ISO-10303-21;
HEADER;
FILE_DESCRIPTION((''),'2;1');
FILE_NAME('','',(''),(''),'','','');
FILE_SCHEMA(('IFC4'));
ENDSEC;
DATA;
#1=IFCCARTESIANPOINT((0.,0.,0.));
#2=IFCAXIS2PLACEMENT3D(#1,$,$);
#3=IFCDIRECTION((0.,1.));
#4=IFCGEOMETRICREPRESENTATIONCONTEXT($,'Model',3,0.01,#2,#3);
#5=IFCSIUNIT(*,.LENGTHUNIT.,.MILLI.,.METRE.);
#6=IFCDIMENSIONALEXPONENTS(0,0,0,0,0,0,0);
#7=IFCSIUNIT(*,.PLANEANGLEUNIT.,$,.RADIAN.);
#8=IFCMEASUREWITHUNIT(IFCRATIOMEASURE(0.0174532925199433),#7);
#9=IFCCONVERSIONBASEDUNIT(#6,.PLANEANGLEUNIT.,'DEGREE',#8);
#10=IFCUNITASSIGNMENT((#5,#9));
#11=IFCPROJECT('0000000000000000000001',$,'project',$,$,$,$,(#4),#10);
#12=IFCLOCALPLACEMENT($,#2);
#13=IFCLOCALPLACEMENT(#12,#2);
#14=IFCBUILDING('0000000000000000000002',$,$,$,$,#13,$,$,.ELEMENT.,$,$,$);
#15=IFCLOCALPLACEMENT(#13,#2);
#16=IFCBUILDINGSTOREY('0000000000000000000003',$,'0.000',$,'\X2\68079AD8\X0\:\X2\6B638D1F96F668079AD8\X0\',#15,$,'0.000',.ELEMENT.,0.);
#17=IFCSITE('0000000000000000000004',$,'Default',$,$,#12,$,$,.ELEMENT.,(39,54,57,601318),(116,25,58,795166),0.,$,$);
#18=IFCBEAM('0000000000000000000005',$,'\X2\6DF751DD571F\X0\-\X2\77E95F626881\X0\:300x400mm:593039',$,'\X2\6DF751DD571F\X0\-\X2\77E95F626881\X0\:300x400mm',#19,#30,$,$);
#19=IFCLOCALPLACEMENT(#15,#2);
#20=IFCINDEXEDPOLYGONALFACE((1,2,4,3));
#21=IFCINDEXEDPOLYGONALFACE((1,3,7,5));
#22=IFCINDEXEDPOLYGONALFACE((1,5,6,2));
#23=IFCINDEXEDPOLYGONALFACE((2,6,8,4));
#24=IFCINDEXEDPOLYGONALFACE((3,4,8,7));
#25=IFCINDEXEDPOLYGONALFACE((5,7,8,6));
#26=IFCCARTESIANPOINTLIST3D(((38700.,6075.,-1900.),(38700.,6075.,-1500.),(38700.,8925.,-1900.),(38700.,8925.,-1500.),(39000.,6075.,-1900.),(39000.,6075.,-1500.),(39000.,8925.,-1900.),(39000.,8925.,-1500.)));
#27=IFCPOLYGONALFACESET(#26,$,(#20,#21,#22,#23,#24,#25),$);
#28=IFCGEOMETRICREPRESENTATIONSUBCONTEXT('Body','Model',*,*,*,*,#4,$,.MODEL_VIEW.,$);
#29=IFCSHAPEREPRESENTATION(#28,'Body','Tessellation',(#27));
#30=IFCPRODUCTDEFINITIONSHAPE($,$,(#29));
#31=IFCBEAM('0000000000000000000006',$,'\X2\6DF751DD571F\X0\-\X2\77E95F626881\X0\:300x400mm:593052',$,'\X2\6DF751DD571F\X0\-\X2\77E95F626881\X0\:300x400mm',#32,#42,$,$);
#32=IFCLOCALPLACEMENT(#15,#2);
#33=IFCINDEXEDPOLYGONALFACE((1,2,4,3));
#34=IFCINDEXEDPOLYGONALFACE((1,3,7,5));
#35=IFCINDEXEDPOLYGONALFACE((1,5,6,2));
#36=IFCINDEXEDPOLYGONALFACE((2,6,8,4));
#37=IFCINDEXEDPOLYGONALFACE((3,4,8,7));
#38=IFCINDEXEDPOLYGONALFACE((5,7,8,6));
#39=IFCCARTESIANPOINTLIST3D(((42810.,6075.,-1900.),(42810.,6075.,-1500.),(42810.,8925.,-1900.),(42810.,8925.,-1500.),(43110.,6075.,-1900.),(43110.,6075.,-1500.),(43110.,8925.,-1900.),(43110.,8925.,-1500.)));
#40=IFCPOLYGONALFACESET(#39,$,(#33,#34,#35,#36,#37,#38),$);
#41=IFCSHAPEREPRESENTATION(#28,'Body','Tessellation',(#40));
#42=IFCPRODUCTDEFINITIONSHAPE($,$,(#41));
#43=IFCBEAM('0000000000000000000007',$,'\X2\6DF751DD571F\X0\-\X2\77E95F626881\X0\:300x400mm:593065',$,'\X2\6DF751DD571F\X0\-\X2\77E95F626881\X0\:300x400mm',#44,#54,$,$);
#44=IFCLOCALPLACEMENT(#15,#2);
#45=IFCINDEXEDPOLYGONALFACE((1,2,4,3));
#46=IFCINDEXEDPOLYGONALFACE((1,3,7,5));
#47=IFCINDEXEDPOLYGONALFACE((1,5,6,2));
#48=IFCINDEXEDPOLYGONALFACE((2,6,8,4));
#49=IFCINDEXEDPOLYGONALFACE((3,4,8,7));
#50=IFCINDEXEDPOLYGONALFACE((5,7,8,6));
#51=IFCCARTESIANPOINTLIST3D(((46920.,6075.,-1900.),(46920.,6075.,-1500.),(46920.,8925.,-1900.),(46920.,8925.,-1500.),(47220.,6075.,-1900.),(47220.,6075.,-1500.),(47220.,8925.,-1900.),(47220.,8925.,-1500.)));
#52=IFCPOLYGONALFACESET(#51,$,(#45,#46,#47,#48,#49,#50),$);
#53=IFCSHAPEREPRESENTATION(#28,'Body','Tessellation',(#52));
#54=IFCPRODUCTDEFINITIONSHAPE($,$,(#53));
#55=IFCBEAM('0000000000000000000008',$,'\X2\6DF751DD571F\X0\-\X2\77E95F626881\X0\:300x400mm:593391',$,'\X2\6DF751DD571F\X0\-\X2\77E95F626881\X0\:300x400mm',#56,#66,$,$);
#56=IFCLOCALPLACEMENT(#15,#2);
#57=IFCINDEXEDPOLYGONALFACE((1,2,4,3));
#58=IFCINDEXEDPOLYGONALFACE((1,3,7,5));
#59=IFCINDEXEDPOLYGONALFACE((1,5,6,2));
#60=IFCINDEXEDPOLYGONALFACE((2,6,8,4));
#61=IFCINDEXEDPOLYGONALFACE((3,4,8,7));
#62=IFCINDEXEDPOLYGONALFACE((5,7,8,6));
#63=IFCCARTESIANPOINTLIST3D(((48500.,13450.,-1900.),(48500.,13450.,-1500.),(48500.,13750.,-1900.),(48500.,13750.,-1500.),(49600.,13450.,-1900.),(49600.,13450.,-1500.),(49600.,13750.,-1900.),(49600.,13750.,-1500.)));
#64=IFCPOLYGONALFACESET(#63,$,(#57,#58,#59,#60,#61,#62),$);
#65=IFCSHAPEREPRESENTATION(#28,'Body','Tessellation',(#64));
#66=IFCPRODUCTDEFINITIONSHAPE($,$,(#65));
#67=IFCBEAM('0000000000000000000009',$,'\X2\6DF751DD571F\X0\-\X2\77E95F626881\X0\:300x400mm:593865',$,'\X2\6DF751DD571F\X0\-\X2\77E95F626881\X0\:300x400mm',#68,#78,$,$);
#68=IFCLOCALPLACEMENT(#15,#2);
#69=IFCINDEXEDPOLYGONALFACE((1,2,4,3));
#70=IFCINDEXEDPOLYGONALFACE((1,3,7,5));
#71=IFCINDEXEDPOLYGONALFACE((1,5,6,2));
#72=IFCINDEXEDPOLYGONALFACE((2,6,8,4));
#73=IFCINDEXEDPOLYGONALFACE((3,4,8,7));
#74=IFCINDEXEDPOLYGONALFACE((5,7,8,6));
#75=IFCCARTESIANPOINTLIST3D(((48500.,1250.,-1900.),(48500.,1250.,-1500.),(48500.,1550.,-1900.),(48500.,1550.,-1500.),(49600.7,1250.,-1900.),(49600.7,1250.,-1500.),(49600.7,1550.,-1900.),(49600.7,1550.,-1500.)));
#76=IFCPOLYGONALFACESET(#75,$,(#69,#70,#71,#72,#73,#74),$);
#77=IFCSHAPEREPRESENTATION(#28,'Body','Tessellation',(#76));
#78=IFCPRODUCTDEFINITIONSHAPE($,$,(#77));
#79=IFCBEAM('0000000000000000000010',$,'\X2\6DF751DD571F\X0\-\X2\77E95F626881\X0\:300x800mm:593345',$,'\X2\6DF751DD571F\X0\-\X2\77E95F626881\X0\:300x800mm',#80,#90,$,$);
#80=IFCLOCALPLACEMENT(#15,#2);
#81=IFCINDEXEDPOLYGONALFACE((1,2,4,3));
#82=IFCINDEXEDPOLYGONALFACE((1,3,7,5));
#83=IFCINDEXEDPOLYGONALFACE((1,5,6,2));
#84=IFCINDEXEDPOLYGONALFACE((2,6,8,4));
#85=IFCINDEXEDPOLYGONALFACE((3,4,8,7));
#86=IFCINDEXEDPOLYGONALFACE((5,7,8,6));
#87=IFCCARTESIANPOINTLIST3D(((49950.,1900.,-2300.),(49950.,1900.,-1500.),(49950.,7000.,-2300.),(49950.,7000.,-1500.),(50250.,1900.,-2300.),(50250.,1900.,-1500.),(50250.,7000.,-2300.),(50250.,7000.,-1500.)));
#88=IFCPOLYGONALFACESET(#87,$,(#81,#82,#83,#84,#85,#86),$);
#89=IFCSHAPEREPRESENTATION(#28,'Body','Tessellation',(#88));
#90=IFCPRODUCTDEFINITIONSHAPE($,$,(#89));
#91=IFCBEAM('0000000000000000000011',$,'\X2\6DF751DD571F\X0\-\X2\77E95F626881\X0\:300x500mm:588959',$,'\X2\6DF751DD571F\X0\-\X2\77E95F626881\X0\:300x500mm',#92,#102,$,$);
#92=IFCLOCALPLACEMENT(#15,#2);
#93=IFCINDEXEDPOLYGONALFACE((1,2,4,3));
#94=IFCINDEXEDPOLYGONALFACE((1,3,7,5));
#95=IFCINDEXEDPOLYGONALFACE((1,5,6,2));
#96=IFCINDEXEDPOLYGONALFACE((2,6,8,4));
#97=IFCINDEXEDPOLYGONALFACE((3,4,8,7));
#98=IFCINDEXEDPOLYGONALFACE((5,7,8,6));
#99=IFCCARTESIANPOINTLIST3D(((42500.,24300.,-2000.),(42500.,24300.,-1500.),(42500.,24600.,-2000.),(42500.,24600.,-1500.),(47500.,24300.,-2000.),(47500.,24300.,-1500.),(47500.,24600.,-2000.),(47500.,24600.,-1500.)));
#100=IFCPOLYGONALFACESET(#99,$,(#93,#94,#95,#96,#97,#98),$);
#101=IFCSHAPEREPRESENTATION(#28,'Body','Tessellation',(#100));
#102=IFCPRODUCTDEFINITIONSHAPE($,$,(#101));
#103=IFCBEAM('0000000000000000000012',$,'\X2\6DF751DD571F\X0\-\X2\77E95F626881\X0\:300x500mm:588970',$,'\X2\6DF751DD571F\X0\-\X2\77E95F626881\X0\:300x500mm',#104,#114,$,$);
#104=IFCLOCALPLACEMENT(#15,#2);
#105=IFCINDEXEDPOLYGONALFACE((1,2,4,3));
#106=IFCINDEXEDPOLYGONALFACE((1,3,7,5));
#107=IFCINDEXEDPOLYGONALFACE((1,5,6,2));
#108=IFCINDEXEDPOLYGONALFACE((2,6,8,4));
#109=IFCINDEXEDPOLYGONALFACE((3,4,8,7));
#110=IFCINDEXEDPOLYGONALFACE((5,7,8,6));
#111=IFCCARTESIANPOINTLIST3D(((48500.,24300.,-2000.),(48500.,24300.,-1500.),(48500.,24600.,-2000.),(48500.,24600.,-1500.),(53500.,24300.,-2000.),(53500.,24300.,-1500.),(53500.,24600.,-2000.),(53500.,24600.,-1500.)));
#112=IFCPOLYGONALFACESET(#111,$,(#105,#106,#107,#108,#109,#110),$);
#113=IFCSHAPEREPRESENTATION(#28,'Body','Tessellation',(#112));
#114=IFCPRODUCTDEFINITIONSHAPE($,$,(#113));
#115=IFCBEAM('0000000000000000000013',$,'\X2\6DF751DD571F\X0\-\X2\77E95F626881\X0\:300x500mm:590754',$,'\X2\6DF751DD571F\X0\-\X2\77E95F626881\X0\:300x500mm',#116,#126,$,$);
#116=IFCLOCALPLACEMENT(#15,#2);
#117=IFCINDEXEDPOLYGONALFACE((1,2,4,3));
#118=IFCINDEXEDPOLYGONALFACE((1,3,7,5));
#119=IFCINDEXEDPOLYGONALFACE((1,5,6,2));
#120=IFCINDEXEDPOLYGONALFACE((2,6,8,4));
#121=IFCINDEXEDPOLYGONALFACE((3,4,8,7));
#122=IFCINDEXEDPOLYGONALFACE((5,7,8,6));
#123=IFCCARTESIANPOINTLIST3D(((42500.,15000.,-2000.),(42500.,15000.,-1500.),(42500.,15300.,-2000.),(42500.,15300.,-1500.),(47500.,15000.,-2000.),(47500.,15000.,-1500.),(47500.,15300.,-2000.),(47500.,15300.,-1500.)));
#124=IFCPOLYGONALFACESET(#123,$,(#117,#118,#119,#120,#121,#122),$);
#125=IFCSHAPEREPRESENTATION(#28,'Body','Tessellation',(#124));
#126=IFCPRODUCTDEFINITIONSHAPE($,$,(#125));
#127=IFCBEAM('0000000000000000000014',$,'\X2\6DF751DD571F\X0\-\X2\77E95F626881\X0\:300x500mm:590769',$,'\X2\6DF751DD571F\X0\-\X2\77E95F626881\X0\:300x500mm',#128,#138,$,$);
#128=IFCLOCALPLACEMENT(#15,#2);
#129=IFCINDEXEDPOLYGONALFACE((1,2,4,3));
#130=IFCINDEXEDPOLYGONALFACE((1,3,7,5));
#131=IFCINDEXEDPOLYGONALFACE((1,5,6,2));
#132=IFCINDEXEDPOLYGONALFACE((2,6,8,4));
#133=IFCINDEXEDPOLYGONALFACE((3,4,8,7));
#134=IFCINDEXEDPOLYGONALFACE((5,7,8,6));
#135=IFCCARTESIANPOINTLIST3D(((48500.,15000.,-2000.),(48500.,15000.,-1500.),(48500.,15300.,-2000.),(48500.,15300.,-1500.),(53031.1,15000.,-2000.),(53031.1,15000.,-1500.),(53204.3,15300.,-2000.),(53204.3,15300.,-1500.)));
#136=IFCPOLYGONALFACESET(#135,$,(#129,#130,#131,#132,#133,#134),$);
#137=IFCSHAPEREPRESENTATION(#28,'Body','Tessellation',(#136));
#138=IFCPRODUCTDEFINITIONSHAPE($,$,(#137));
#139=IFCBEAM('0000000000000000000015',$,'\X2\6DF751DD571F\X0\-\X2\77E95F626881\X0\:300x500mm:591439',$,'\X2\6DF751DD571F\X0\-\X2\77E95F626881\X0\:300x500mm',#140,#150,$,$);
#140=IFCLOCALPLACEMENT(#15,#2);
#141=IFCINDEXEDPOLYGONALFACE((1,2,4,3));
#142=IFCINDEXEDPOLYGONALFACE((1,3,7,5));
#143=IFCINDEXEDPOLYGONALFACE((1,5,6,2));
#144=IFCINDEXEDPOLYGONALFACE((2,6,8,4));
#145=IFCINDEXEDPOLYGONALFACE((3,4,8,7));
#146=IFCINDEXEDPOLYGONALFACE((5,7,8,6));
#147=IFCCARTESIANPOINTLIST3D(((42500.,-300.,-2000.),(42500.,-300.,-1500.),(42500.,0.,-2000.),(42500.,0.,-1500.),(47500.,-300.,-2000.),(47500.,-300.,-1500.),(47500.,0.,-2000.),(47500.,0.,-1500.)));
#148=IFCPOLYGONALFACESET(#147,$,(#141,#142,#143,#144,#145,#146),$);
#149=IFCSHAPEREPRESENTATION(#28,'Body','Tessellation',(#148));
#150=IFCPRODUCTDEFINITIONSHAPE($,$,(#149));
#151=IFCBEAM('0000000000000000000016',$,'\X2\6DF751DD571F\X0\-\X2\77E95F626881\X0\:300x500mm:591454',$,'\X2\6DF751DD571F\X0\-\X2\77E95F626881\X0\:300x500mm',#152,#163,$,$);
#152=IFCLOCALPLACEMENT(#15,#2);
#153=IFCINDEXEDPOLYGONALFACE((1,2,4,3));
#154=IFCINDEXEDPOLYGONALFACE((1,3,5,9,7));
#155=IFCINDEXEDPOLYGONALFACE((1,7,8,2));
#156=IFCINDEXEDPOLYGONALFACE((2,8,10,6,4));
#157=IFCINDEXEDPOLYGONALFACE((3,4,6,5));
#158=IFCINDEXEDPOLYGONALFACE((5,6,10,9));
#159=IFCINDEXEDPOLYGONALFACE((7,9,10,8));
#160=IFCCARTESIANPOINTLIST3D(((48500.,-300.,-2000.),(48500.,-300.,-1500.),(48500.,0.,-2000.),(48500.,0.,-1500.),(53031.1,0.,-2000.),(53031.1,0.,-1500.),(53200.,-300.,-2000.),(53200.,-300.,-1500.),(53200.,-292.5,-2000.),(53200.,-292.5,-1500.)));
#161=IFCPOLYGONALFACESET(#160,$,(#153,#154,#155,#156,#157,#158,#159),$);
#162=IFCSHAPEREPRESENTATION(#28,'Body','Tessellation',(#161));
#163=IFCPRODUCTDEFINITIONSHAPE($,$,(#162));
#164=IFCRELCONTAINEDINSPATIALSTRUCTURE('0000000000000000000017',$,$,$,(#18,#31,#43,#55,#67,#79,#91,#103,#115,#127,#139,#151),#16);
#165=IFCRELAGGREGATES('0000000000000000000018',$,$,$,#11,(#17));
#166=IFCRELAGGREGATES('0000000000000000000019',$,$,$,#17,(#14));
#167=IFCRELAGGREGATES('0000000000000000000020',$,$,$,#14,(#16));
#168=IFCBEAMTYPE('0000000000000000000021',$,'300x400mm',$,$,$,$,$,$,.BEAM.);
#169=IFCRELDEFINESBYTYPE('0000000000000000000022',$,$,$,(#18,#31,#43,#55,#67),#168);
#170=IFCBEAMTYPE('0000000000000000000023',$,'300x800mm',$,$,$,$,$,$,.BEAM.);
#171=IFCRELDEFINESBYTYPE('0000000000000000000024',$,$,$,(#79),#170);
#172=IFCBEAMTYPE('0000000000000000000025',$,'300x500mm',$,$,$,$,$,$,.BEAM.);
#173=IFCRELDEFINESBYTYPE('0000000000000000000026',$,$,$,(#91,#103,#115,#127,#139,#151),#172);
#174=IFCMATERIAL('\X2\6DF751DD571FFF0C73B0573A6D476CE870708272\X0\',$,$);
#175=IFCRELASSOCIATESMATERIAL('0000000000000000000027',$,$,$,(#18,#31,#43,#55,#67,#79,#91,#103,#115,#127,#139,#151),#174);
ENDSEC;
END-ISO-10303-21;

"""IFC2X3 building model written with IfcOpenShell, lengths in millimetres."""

from ifc_helpers import new_model, entity, si_unit, converted_unit, direction, frame, frame_2d, origin, place, context, subcontext, project, spatial, rectangle, extrude, clip, halfspace, material, type_object, element, save


model = new_model("IFC2X3")

# Units and contexts
model_context = context("Model", 3, precision=0.01, world=origin(), true_north=direction((0.0, 1.0)))
body_context = subcontext(model_context, "Body", "Model", "MODEL_VIEW")
ifc_project = project(units=[si_unit("LENGTHUNIT", "METRE", prefix="MILLI"), converted_unit("PLANEANGLEUNIT", "DEGREE", entity("IfcRatioMeasure", 0.0174532925199433), si_unit("PLANEANGLEUNIT", "RADIAN"), dimensions=[0, 0, 0, 0, 0, 0, 0])], contexts=[model_context])

# Site, building, storey
site_placement = place(None, origin())
site = spatial("IfcSite", under=ifc_project, at=site_placement, Name="Default", CompositionType="ELEMENT", RefLatitude=(39, 54, 57, 601318), RefLongitude=(116, 25, 58, 795166), RefElevation=0.0)
building_placement = place(site_placement, origin())
building = spatial("IfcBuilding", under=site, at=building_placement, CompositionType="ELEMENT")
storey_placement = place(building_placement, origin())
storey = spatial("IfcBuildingStorey", under=building, at=storey_placement, Name="0.000", ObjectType="标高:正负零标高", LongName="0.000", CompositionType="ELEMENT", Elevation=0.0)

# Shared definitions
ifc_material = material(Name="混凝土，现场浇注灰色")

# Beams
beam_type_1 = type_object("IfcBeamType", Name="300x400mm", PredefinedType="BEAM")
beam_1_placement = place(storey_placement, frame((38850.0, 8925.0, -1500.0), z_axis=(0.0, 0.0, 1.0), x_axis=(0.0, -1.0, 0.0)))
element("IfcBeam", 1, at=beam_1_placement, inside=storey, type_object=beam_type_1, material=ifc_material, Name="混凝土-矩形梁:300x400mm:593039", ObjectType="混凝土-矩形梁:300x400mm", context=body_context, shape_type="SweptSolid", body=[
    extrude(rectangle(XDim=400.0, YDim=300.0, at=frame_2d((0.0, 0.0), x_axis=(1.0, 0.0))), frame((0.0, 0.0, -200.0), z_axis=(1.0, 0.0, 0.0), x_axis=(0.0, 0.0, -1.0)), (0.0, 0.0, 1.0), 2850.0),
])
for number, where, z_axis, x_axis, name in (
    (2, (42960.0, 8925.0, -1500.0), (0.0, 0.0, 1.0), (0.0, -1.0, 0.0), "混凝土-矩形梁:300x400mm:593052"),
    (3, (47070.0, 8925.0, -1500.0), (0.0, 0.0, 1.0), (0.0, -1.0, 0.0), "混凝土-矩形梁:300x400mm:593065"),
):
    element("IfcBeam", number, at=place(storey_placement, frame(where, z_axis=z_axis, x_axis=x_axis)), inside=storey, type_object=beam_type_1, material=ifc_material, Name=name, ObjectType="混凝土-矩形梁:300x400mm", context=body_context, shape_type="SweptSolid", body=[
        extrude(rectangle(XDim=400.0, YDim=300.0, at=frame_2d((0.0, 0.0), x_axis=(1.0, 0.0))), frame((0.0, 0.0, -200.0), z_axis=(1.0, 0.0, 0.0), x_axis=(0.0, 0.0, -1.0)), (0.0, 0.0, 1.0), 2850.0),
    ])
beam_2_placement = place(storey_placement, frame((49600.0, 13600.0, -1500.0), z_axis=(0.0, 0.0, 1.0), x_axis=(-1.0, 0.0, 0.0)))
element("IfcBeam", 4, at=beam_2_placement, inside=storey, type_object=beam_type_1, material=ifc_material, Name="混凝土-矩形梁:300x400mm:593391", ObjectType="混凝土-矩形梁:300x400mm", context=body_context, shape_type="SweptSolid", body=[
    extrude(rectangle(XDim=400.0, YDim=300.0, at=frame_2d((0.0, 0.0), x_axis=(1.0, 0.0))), frame((0.0, 0.0, -200.0), z_axis=(1.0, 0.0, 0.0), x_axis=(0.0, 0.0, -1.0)), (0.0, 0.0, 1.0), 1100.0),
])
beam_3_placement = place(storey_placement, frame((48500.0, 1400.0, -1500.0)))
element("IfcBeam", 5, at=beam_3_placement, inside=storey, type_object=beam_type_1, material=ifc_material, Name="混凝土-矩形梁:300x400mm:593865", ObjectType="混凝土-矩形梁:300x400mm", context=body_context, shape_type="SweptSolid", body=[
    extrude(rectangle(XDim=400.0, YDim=300.0, at=frame_2d((0.0, 0.0), x_axis=(1.0, 0.0))), frame((0.0, 0.0, -200.0), z_axis=(1.0, 0.0, 0.0), x_axis=(0.0, 0.0, -1.0)), (0.0, 0.0, 1.0), 1100.7),
])
beam_type_2 = type_object("IfcBeamType", Name="300x800mm", PredefinedType="BEAM")
beam_4_placement = place(storey_placement, frame((50100.0, 7000.0, -1500.0), z_axis=(0.0, 0.0, 1.0), x_axis=(0.0, -1.0, 0.0)))
element("IfcBeam", 6, at=beam_4_placement, inside=storey, type_object=beam_type_2, material=ifc_material, Name="混凝土-矩形梁:300x800mm:593345", ObjectType="混凝土-矩形梁:300x800mm", context=body_context, shape_type="SweptSolid", body=[
    extrude(rectangle(XDim=800.0, YDim=300.0, at=frame_2d((0.0, 0.0), x_axis=(1.0, 0.0))), frame((0.0, 0.0, -400.0), z_axis=(1.0, 0.0, 0.0), x_axis=(0.0, 0.0, -1.0)), (0.0, 0.0, 1.0), 5100.0),
])
beam_type_3 = type_object("IfcBeamType", Name="300x500mm", PredefinedType="BEAM")
for number, where, name in (
    (7, (42500.0, 24450.0, -1500.0), "混凝土-矩形梁:300x500mm:588959"),
    (8, (48500.0, 24450.0, -1500.0), "混凝土-矩形梁:300x500mm:588970"),
):
    element("IfcBeam", number, at=place(storey_placement, frame(where)), inside=storey, type_object=beam_type_3, material=ifc_material, Name=name, ObjectType="混凝土-矩形梁:300x500mm", context=body_context, shape_type="SweptSolid", body=[
        extrude(rectangle(XDim=500.0, YDim=300.0, at=frame_2d((0.0, 0.0), x_axis=(1.0, 0.0))), frame((0.0, 0.0, -250.0), z_axis=(1.0, 0.0, 0.0), x_axis=(0.0, 0.0, -1.0)), (0.0, 0.0, 1.0), 5000.0),
    ])
beam_5_placement = place(storey_placement, frame((42500.0, 15150.0, -1500.0)))
element("IfcBeam", 9, at=beam_5_placement, inside=storey, type_object=beam_type_3, material=ifc_material, Name="混凝土-矩形梁:300x500mm:590754", ObjectType="混凝土-矩形梁:300x500mm", context=body_context, shape_type="SweptSolid", body=[
    extrude(rectangle(XDim=500.0, YDim=300.0, at=frame_2d((0.0, 0.0), x_axis=(1.0, 0.0))), frame((0.0, 0.0, -250.0), z_axis=(1.0, 0.0, 0.0), x_axis=(0.0, 0.0, -1.0)), (0.0, 0.0, 1.0), 5000.0),
])
beam_6_placement = place(storey_placement, frame((48500.0, 15150.0, -1500.0)))
element("IfcBeam", 10, at=beam_6_placement, inside=storey, type_object=beam_type_3, material=ifc_material, Name="混凝土-矩形梁:300x500mm:590769", ObjectType="混凝土-矩形梁:300x500mm", context=body_context, shape_type="Clipping", body=[
    clip(extrude(rectangle(XDim=500.0, YDim=300.0, at=frame_2d((0.0, 0.0), x_axis=(1.0, 0.0))), frame((0.0, 0.0, -250.0), z_axis=(1.0, 0.0, 0.0), x_axis=(0.0, 0.0, -1.0)), (0.0, 0.0, 1.0), 4704.3), halfspace(frame((5211.4, 1028.0, 0.0), z_axis=(0.865977, -0.500083, 0.0), x_axis=(0.0, 0.0, -1.0)), False)),
])
beam_7_placement = place(storey_placement, frame((42500.0, -150.0, -1500.0)))
element("IfcBeam", 11, at=beam_7_placement, inside=storey, type_object=beam_type_3, material=ifc_material, Name="混凝土-矩形梁:300x500mm:591439", ObjectType="混凝土-矩形梁:300x500mm", context=body_context, shape_type="SweptSolid", body=[
    extrude(rectangle(XDim=500.0, YDim=300.0, at=frame_2d((0.0, 0.0), x_axis=(1.0, 0.0))), frame((0.0, 0.0, -250.0), z_axis=(1.0, 0.0, 0.0), x_axis=(0.0, 0.0, -1.0)), (0.0, 0.0, 1.0), 5000.0),
])
beam_8_placement = place(storey_placement, frame((48500.0, -150.0, -1500.0)))
element("IfcBeam", 12, at=beam_8_placement, inside=storey, type_object=beam_type_3, material=ifc_material, Name="混凝土-矩形梁:300x500mm:591454", ObjectType="混凝土-矩形梁:300x500mm", context=body_context, shape_type="Clipping", body=[
    clip(extrude(rectangle(XDim=500.0, YDim=300.0, at=frame_2d((0.0, 0.0), x_axis=(1.0, 0.0))), frame((0.0, 0.0, -250.0), z_axis=(1.0, 0.0, 0.0), x_axis=(0.0, 0.0, -1.0)), (0.0, 0.0, 1.0), 4700.0), halfspace(frame((5211.4, -1028.0, 0.0), z_axis=(0.865977, 0.500083, 0.0), x_axis=(0.0, 0.0, -1.0)), False)),
])

save(model, "model.ifc")
